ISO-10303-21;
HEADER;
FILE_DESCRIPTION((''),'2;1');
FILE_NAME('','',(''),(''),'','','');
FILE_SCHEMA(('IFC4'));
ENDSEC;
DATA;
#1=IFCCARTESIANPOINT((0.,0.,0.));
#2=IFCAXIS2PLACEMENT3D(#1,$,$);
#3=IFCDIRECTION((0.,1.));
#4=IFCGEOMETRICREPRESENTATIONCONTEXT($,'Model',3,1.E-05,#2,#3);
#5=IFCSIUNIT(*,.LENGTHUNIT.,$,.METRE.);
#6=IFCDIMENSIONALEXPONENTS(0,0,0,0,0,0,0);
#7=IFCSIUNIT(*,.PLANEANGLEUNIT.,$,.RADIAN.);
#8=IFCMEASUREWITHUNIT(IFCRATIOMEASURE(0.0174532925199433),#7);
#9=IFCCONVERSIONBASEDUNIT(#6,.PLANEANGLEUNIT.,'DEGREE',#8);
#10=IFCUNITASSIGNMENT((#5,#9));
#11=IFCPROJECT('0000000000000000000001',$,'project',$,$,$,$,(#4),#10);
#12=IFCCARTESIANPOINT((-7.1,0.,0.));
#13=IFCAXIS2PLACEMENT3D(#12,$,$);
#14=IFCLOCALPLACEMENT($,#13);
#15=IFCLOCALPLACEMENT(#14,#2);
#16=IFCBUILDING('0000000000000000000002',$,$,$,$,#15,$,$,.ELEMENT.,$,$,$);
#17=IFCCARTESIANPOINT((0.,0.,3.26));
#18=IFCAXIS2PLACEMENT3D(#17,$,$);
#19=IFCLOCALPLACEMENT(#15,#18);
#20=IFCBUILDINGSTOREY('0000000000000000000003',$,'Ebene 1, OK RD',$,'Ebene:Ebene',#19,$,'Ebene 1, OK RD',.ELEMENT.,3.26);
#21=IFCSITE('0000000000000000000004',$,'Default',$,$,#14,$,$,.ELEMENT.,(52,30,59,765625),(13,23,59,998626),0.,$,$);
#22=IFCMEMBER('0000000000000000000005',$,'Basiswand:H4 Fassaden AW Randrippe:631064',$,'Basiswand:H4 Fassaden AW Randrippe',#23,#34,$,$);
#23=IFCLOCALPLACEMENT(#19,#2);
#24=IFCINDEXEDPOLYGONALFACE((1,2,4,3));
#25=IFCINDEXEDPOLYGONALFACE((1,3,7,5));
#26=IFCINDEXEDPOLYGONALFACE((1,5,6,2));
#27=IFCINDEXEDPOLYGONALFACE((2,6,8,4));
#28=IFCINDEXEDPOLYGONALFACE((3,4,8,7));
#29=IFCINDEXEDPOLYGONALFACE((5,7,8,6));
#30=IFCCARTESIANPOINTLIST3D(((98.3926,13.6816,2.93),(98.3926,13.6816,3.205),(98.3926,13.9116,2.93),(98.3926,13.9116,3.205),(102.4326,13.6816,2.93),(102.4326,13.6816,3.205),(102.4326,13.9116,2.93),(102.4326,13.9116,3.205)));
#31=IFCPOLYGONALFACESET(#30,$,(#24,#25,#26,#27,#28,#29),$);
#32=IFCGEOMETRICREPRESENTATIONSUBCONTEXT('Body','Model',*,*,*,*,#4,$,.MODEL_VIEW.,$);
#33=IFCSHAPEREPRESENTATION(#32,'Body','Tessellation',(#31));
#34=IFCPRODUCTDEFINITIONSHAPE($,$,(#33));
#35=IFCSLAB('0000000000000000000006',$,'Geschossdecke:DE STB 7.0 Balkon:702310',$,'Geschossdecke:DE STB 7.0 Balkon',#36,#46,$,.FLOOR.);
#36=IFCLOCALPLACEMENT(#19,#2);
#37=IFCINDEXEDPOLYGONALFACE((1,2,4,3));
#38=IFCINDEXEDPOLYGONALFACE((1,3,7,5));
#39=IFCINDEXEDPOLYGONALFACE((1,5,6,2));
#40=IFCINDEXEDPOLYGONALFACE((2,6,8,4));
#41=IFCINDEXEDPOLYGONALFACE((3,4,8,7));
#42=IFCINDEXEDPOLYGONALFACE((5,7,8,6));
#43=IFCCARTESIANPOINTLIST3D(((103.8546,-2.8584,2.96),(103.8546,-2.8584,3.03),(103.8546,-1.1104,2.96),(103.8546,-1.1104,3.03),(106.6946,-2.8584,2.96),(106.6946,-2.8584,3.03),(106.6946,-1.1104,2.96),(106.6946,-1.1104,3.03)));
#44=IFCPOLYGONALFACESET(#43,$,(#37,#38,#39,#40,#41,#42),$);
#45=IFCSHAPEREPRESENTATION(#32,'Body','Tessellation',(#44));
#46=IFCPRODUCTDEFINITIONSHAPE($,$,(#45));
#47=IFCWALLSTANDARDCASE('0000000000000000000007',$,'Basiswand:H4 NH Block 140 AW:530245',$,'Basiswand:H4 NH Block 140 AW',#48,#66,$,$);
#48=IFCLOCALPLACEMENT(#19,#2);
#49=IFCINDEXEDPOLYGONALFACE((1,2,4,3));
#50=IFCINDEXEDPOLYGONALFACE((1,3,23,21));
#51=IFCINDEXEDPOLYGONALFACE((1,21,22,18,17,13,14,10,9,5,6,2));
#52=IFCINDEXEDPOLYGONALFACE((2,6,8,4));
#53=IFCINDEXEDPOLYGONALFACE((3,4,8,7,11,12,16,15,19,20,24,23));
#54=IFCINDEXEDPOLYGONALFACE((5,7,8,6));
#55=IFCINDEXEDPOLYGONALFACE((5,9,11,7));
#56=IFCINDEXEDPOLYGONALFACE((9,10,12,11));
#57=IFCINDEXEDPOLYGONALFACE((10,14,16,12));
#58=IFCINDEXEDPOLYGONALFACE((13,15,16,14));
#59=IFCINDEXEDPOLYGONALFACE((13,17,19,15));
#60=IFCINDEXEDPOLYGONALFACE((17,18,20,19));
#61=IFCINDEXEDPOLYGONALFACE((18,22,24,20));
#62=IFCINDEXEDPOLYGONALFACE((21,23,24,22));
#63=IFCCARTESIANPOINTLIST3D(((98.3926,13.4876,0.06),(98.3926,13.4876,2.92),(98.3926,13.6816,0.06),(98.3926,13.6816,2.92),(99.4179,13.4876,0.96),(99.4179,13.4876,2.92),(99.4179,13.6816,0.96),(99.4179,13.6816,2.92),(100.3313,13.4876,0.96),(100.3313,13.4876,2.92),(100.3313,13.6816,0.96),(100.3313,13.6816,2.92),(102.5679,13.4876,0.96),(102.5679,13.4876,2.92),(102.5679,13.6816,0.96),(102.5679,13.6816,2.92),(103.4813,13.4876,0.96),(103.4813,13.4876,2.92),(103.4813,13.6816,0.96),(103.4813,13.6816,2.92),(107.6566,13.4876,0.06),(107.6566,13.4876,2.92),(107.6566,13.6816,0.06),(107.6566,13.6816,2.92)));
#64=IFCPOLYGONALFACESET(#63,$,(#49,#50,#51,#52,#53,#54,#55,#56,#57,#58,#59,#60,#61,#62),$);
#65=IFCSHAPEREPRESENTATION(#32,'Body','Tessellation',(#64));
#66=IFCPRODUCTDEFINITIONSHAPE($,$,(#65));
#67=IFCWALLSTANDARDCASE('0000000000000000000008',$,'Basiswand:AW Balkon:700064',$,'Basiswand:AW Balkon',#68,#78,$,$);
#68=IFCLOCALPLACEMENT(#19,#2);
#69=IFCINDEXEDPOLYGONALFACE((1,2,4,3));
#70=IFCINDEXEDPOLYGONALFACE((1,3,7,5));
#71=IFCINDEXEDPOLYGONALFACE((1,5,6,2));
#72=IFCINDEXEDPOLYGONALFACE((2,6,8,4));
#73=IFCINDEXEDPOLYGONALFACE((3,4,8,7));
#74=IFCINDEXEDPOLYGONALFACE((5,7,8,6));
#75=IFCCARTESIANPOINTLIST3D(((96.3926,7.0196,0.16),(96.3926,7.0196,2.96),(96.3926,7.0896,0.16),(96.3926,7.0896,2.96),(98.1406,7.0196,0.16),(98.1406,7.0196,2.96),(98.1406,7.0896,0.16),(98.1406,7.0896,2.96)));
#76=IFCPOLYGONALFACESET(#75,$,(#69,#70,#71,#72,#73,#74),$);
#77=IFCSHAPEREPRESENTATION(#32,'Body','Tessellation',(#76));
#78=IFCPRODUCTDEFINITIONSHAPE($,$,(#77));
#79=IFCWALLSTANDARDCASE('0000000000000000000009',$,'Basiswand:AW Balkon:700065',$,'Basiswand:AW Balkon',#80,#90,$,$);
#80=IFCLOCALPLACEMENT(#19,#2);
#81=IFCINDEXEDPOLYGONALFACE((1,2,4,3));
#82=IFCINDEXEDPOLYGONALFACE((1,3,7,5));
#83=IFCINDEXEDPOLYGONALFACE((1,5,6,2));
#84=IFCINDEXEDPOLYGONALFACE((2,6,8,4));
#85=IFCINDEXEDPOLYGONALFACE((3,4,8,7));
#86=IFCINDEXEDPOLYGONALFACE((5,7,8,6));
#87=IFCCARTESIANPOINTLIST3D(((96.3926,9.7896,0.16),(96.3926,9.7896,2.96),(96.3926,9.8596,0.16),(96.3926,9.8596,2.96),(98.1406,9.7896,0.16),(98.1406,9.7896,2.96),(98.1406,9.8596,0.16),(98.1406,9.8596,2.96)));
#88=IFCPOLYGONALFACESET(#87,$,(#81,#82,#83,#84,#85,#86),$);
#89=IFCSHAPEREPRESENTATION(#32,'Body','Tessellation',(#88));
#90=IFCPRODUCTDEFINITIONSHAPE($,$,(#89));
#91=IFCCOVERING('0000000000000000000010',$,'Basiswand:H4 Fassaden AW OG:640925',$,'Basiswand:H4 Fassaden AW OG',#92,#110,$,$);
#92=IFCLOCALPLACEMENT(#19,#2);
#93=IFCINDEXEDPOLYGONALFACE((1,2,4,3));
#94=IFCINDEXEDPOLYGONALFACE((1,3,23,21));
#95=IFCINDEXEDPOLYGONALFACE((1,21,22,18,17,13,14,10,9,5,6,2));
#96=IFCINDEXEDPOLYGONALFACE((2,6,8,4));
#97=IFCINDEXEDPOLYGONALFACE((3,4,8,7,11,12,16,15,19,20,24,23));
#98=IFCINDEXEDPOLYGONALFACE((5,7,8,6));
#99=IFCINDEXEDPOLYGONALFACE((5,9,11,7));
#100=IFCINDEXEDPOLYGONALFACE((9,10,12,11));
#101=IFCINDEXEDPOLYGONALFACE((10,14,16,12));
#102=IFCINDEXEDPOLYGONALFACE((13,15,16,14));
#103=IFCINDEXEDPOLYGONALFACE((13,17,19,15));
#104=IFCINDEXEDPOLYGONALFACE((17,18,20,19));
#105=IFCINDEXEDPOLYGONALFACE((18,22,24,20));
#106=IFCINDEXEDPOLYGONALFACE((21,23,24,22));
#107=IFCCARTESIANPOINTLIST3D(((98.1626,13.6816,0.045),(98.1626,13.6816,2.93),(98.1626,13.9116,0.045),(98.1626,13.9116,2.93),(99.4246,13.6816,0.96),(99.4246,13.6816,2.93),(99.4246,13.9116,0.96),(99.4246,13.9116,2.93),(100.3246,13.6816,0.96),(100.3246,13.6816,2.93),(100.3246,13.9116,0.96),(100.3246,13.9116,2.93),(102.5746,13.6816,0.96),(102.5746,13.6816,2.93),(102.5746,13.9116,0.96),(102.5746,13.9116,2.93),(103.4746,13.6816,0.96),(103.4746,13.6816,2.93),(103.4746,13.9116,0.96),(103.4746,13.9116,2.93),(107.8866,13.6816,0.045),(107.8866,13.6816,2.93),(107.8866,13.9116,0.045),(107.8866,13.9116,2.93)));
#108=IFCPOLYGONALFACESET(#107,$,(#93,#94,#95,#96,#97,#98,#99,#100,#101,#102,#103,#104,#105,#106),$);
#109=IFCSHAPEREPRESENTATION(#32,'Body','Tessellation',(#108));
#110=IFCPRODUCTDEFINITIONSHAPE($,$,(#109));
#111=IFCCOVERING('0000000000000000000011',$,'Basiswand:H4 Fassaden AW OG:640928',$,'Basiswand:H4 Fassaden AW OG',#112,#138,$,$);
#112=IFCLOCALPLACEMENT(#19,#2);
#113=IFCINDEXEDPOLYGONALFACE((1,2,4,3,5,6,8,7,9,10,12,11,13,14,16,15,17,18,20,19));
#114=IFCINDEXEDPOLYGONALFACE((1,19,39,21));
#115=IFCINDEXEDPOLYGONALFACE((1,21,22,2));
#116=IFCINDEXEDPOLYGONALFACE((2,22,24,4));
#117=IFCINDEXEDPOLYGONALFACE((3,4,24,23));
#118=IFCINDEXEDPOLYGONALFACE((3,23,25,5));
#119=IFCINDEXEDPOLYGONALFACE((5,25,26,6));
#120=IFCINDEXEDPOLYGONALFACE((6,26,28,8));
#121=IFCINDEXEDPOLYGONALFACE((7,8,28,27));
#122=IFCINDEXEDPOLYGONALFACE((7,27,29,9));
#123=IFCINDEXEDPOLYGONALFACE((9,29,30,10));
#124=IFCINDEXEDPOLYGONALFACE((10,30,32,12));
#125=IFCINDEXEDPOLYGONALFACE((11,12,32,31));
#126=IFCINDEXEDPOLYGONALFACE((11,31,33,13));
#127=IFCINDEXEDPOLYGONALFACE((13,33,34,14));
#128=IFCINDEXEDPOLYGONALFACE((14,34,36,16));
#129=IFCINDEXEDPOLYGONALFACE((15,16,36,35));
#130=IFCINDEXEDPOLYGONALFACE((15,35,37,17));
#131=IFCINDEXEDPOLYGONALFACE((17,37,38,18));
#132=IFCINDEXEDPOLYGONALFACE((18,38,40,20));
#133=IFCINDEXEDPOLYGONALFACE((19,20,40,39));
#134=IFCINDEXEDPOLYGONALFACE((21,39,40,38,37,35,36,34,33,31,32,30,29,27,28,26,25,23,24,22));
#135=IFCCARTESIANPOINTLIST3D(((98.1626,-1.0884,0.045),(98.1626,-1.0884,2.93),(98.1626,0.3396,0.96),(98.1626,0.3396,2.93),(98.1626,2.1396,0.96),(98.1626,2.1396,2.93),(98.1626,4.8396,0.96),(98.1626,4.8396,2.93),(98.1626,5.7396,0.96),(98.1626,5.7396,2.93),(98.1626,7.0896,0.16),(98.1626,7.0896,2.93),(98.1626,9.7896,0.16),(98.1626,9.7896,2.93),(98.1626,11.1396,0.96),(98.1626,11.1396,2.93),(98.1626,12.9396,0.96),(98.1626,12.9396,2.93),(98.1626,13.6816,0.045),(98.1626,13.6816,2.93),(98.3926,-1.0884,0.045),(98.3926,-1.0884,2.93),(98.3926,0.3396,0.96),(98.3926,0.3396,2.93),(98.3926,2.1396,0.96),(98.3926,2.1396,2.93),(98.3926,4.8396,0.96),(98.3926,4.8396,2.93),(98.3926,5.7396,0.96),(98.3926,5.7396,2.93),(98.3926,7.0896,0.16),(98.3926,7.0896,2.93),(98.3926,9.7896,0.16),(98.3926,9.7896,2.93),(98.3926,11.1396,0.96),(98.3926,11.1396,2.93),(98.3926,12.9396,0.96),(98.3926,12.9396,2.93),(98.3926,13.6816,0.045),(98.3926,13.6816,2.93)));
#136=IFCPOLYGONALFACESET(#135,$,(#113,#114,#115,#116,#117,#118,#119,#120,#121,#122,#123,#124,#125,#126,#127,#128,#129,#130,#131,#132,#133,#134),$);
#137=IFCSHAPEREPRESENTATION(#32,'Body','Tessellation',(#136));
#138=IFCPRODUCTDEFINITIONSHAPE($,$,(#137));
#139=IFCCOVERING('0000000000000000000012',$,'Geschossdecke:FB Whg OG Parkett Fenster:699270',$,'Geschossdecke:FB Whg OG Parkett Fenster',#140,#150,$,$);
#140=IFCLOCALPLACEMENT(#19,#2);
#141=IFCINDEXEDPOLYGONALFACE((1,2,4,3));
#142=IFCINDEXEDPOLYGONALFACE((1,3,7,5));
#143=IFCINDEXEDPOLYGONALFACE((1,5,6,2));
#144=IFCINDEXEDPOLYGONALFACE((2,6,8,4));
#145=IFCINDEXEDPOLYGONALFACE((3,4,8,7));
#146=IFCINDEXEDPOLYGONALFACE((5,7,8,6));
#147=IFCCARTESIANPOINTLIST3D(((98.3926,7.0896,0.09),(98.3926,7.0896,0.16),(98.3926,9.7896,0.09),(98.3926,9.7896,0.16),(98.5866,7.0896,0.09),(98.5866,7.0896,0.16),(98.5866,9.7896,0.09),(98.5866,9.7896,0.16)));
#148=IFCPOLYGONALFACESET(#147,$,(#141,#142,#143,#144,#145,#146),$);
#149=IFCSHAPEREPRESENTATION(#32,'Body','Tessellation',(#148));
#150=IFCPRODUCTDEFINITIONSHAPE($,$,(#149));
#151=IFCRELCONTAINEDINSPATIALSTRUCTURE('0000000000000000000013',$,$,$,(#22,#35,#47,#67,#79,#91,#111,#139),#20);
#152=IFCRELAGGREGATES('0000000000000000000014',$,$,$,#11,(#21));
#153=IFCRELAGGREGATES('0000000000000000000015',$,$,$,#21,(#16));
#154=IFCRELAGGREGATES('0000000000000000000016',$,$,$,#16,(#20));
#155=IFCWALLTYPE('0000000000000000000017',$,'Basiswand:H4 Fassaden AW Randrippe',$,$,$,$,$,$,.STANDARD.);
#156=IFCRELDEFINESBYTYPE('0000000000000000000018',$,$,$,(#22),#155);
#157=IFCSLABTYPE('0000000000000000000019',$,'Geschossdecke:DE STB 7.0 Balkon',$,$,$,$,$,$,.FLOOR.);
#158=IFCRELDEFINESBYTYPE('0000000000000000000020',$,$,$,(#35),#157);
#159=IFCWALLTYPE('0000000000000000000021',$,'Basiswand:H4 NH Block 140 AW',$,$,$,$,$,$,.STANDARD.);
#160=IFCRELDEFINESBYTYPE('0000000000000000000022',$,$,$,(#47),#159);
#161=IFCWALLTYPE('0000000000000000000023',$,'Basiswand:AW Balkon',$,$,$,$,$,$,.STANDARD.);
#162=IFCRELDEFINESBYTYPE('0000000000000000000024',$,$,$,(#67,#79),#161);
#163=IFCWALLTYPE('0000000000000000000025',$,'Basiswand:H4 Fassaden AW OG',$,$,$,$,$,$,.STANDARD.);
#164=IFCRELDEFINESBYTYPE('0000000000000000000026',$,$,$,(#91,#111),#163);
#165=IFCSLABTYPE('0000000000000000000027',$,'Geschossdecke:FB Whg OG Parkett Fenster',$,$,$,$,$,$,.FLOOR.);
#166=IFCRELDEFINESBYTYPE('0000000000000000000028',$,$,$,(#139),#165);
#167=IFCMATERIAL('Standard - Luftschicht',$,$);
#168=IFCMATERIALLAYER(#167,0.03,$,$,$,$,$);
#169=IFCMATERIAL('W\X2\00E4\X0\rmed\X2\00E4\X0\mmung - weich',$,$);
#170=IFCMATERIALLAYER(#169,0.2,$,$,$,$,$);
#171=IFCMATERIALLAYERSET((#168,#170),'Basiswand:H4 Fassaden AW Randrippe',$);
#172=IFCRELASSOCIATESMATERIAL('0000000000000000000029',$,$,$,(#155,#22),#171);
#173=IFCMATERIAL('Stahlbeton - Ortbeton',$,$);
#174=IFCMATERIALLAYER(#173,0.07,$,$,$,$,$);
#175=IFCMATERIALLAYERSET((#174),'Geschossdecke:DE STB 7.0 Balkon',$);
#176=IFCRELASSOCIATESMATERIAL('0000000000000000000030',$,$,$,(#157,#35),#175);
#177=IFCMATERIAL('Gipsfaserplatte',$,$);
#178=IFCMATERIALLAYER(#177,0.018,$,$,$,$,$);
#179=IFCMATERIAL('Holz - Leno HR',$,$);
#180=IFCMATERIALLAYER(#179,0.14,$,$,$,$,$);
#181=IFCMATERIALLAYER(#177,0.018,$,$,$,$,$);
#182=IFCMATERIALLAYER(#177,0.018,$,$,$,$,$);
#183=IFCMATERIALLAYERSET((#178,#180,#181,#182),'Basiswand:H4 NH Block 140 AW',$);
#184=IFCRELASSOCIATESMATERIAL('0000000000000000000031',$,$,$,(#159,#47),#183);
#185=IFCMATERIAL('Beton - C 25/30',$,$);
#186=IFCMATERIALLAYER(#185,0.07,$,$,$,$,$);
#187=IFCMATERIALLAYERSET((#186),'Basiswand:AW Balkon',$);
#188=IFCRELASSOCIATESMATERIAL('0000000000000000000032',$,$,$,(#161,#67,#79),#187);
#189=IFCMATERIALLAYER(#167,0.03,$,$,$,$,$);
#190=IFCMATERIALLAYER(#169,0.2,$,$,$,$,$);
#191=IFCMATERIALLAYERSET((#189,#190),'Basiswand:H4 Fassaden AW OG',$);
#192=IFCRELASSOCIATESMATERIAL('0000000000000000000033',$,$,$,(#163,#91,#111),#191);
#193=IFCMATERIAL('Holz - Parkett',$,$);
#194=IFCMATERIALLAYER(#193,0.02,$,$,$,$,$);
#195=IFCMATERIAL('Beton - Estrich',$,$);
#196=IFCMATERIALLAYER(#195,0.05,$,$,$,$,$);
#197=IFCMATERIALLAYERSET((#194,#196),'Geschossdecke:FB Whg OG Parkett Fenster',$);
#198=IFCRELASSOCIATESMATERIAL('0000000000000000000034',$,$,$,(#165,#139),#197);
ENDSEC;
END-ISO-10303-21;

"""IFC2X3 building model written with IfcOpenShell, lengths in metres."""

from ifc_helpers import new_model, entity, si_unit, converted_unit, direction, frame, frame_2d, origin, origin_2d_with_axis, place, context, subcontext, project, spatial, rectangle, extrude, material, layer, layer_set, layer_usage, type_object, element, save


model = new_model("IFC2X3")

# Units and contexts
model_context = context("Model", 3, precision=1e-05, world=origin(), true_north=direction((0.0, 1.0)))
body_context = subcontext(model_context, "Body", "Model", "MODEL_VIEW")
ifc_project = project(units=[si_unit("LENGTHUNIT", "METRE"), converted_unit("PLANEANGLEUNIT", "DEGREE", entity("IfcRatioMeasure", 0.0174532925199433), si_unit("PLANEANGLEUNIT", "RADIAN"), dimensions=[0, 0, 0, 0, 0, 0, 0])], contexts=[model_context])

# Site, building, storey
site_placement = place(None, frame((-7.1, 0.0, 0.0)))
site = spatial("IfcSite", under=ifc_project, at=site_placement, Name="Default", CompositionType="ELEMENT", RefLatitude=(52, 30, 59, 765625), RefLongitude=(13, 23, 59, 998626), RefElevation=0.0)
building_placement = place(site_placement, origin())
building = spatial("IfcBuilding", under=site, at=building_placement, CompositionType="ELEMENT")
storey_placement = place(building_placement, frame((0.0, 0.0, 3.26)))
storey = spatial("IfcBuildingStorey", under=building, at=storey_placement, Name="Ebene 1, OK RD", ObjectType="Ebene:Ebene", LongName="Ebene 1, OK RD", CompositionType="ELEMENT", Elevation=3.26)

# Shared definitions
ifc_material_1 = material(Name="Gipsfaserplatte")

# Member
ifc_material_2 = material(Name="Standard - Luftschicht")
ifc_layer_1 = layer(ifc_material_2, 0.03)
ifc_material_3 = material(Name="Wärmedämmung - weich")
ifc_layer_2 = layer(ifc_material_3, 0.2)
ifc_layer_set_1 = layer_set([ifc_layer_1, ifc_layer_2], Name="Basiswand:H4 Fassaden AW Randrippe")
ifc_layer_usage_1 = layer_usage(ifc_layer_set_1, "AXIS2", "NEGATIVE", 0.115)
wall_type_1 = type_object("IfcWallType", Name="Basiswand:H4 Fassaden AW Randrippe", PredefinedType="STANDARD", material=ifc_layer_set_1)
member_1_placement = place(storey_placement, frame((98.3926, 13.7966, 2.93)))
element("IfcMember", 1, at=member_1_placement, inside=storey, type_object=wall_type_1, material=ifc_layer_usage_1, Name="Basiswand:H4 Fassaden AW Randrippe:631064", ObjectType="Basiswand:H4 Fassaden AW Randrippe", context=body_context, shape_type="SweptSolid", body=[
    extrude(rectangle(XDim=4.04, YDim=0.23, at=frame_2d((2.02, 0.0), x_axis=(-1.0, 0.0))), origin(), (0.0, 0.0, 1.0), 0.275),
])

# Slab
ifc_material_4 = material(Name="Stahlbeton - Ortbeton")
ifc_layer_3 = layer(ifc_material_4, 0.07)
ifc_layer_set_2 = layer_set([ifc_layer_3], Name="Geschossdecke:DE STB 7.0 Balkon")
ifc_layer_usage_2 = layer_usage(ifc_layer_set_2, "AXIS3", "POSITIVE", 0.0)
slab_type_1 = type_object("IfcSlabType", Name="Geschossdecke:DE STB 7.0 Balkon", PredefinedType="FLOOR", material=ifc_layer_set_2)
slab_placement = place(storey_placement, origin())
element("IfcSlab", 2, at=slab_placement, inside=storey, type_object=slab_type_1, material=ifc_layer_usage_2, Name="Geschossdecke:DE STB 7.0 Balkon:702310", ObjectType="Geschossdecke:DE STB 7.0 Balkon", PredefinedType="FLOOR", context=body_context, shape_type="SweptSolid", body=[
    extrude(rectangle(XDim=1.748, YDim=2.84, at=frame_2d((0.0, 0.0), x_axis=(1.0, 0.0))), frame((105.2746, -1.9844, 3.03), z_axis=(0.0, 0.0, -1.0), x_axis=(0.0, 1.0, 0.0)), (0.0, 0.0, 1.0), 0.07),
])

# Wall, openings
ifc_layer_4 = layer(ifc_material_1, 0.018)
ifc_material_5 = material(Name="Holz - Leno HR")
ifc_layer_5 = layer(ifc_material_5, 0.14)
ifc_layer_6 = layer(ifc_material_1, 0.018)
ifc_layer_7 = layer(ifc_material_1, 0.018)
ifc_layer_set_3 = layer_set([ifc_layer_4, ifc_layer_5, ifc_layer_6, ifc_layer_7], Name="Basiswand:H4 NH Block 140 AW")
ifc_layer_usage_3 = layer_usage(ifc_layer_set_3, "AXIS2", "NEGATIVE", 0.097)
wall_type_2 = type_object("IfcWallType", Name="Basiswand:H4 NH Block 140 AW", PredefinedType="STANDARD", material=ifc_layer_set_3)
wall_1_placement = place(storey_placement, frame((98.3926, 13.5846, 0.06)))
wall_1 = element("IfcWallStandardCase", 3, at=wall_1_placement, inside=storey, type_object=wall_type_2, material=ifc_layer_usage_3, Name="Basiswand:H4 NH Block 140 AW:530245", ObjectType="Basiswand:H4 NH Block 140 AW", context=body_context, shape_type="SweptSolid", body=[
    extrude(rectangle(XDim=9.264, YDim=0.194, at=frame_2d((4.632, 0.0), x_axis=(-1.0, 0.0))), origin(), (0.0, 0.0, 1.0), 2.86),
])
opening_1_placement = place(wall_1_placement, origin())
element("IfcOpeningElement", 4, at=opening_1_placement, cuts=wall_1, ObjectType="Opening", context=body_context, shape_type="SweptSolid", body=[
    extrude(rectangle(XDim=2.0, YDim=0.9134, at=origin_2d_with_axis()), frame((1.482, -0.097, 1.9), z_axis=(0.0, 1.0, 0.0), x_axis=(0.0, 0.0, -1.0)), (0.0, 0.0, 1.0), 0.194),
])
opening_2_placement = place(wall_1_placement, origin())
element("IfcOpeningElement", 5, at=opening_2_placement, cuts=wall_1, ObjectType="Opening", context=body_context, shape_type="SweptSolid", body=[
    extrude(rectangle(XDim=2.0, YDim=0.9134, at=origin_2d_with_axis()), frame((4.632, -0.097, 1.9), z_axis=(0.0, 1.0, 0.0), x_axis=(0.0, 0.0, -1.0)), (0.0, 0.0, 1.0), 0.194),
])

# Walls
ifc_material_6 = material(Name="Beton - C 25/30")
ifc_layer_8 = layer(ifc_material_6, 0.07)
ifc_layer_set_4 = layer_set([ifc_layer_8], Name="Basiswand:AW Balkon")
ifc_layer_usage_4 = layer_usage(ifc_layer_set_4, "AXIS2", "NEGATIVE", 0.035)
wall_type_3 = type_object("IfcWallType", Name="Basiswand:AW Balkon", PredefinedType="STANDARD", material=ifc_layer_set_4)
wall_2_placement = place(storey_placement, frame((98.1406, 7.0546, 0.16), z_axis=(0.0, 0.0, 1.0), x_axis=(-1.0, 0.0, 0.0)))
element("IfcWallStandardCase", 6, at=wall_2_placement, inside=storey, type_object=wall_type_3, material=ifc_layer_usage_4, Name="Basiswand:AW Balkon:700064", ObjectType="Basiswand:AW Balkon", context=body_context, shape_type="SweptSolid", body=[
    extrude(rectangle(XDim=1.748, YDim=0.07, at=frame_2d((0.874, 0.0), x_axis=(-1.0, 0.0))), origin(), (0.0, 0.0, 1.0), 2.8),
])
ifc_layer_usage_5 = layer_usage(ifc_layer_set_4, "AXIS2", "NEGATIVE", 0.035)
wall_3_placement = place(storey_placement, frame((96.3926, 9.8246, 0.16)))
element("IfcWallStandardCase", 7, at=wall_3_placement, inside=storey, type_object=wall_type_3, material=ifc_layer_usage_5, Name="Basiswand:AW Balkon:700065", ObjectType="Basiswand:AW Balkon", context=body_context, shape_type="SweptSolid", body=[
    extrude(rectangle(XDim=1.748, YDim=0.07, at=frame_2d((0.874, 0.0), x_axis=(-1.0, 0.0))), origin(), (0.0, 0.0, 1.0), 2.8),
])

# Coverings, openings
ifc_layer_9 = layer(ifc_material_2, 0.03)
ifc_layer_10 = layer(ifc_material_3, 0.2)
ifc_layer_set_5 = layer_set([ifc_layer_9, ifc_layer_10], Name="Basiswand:H4 Fassaden AW OG")
ifc_layer_usage_6 = layer_usage(ifc_layer_set_5, "AXIS2", "NEGATIVE", 0.115)
wall_type_4 = type_object("IfcWallType", Name="Basiswand:H4 Fassaden AW OG", PredefinedType="STANDARD", material=ifc_layer_set_5)
covering_1_placement = place(storey_placement, frame((98.1626, 13.7966, 0.045)))
covering_1 = element("IfcCovering", 8, at=covering_1_placement, inside=storey, type_object=wall_type_4, material=ifc_layer_usage_6, Name="Basiswand:H4 Fassaden AW OG:640925", ObjectType="Basiswand:H4 Fassaden AW OG", context=body_context, shape_type="SweptSolid", body=[
    extrude(rectangle(XDim=9.724, YDim=0.23, at=frame_2d((4.862, 0.0), x_axis=(-1.0, 0.0))), origin(), (0.0, 0.0, 1.0), 2.885),
])
opening_3_placement = place(covering_1_placement, frame((2.162, 0.115, 0.915)))
element("IfcOpeningElement", 9, at=opening_3_placement, cuts=covering_1, ObjectType="Opening", context=body_context, shape_type="SweptSolid", body=[
    extrude(rectangle(XDim=1.97, YDim=0.9, at=frame_2d((0.985, 0.45), x_axis=(1.0, 0.0))), frame((0.0, 0.0, 0.0), z_axis=(0.0, -1.0, 0.0), x_axis=(0.0, 0.0, 1.0)), (0.0, 0.0, 1.0), 0.23),
])
opening_4_placement = place(covering_1_placement, frame((5.312, 0.115, 0.915)))
element("IfcOpeningElement", 10, at=opening_4_placement, cuts=covering_1, ObjectType="Opening", context=body_context, shape_type="SweptSolid", body=[
    extrude(rectangle(XDim=1.97, YDim=0.9, at=frame_2d((0.985, 0.45), x_axis=(1.0, 0.0))), frame((0.0, 0.0, 0.0), z_axis=(0.0, -1.0, 0.0), x_axis=(0.0, 0.0, 1.0)), (0.0, 0.0, 1.0), 0.23),
])
ifc_layer_usage_7 = layer_usage(ifc_layer_set_5, "AXIS2", "NEGATIVE", 0.115)
covering_2_placement = place(storey_placement, frame((98.2776, -1.0884, 0.045), z_axis=(0.0, 0.0, 1.0), x_axis=(0.0, 1.0, 0.0)))
covering_2 = element("IfcCovering", 11, at=covering_2_placement, inside=storey, type_object=wall_type_4, material=ifc_layer_usage_7, Name="Basiswand:H4 Fassaden AW OG:640928", ObjectType="Basiswand:H4 Fassaden AW OG", context=body_context, shape_type="SweptSolid", body=[
    extrude(rectangle(XDim=14.77, YDim=0.23, at=frame_2d((7.385, 0.0), x_axis=(-1.0, 0.0))), origin(), (0.0, 0.0, 1.0), 2.885),
])
opening_5_placement = place(covering_2_placement, origin())
element("IfcOpeningElement", 12, at=opening_5_placement, cuts=covering_2, ObjectType="Opening", context=body_context, shape_type="SweptSolid", body=[
    extrude(rectangle(XDim=2.8, YDim=2.7, at=frame_2d((0.0, 0.0), x_axis=(0.0, 1.0))), frame((9.528, -0.2674, 1.515), z_axis=(0.0, 1.0, 0.0), x_axis=(-1.0, 0.0, 0.0)), (0.0, 0.0, 1.0), 0.5348),
])
opening_6_placement = place(covering_2_placement, frame((3.228, 0.115, 0.915)))
element("IfcOpeningElement", 13, at=opening_6_placement, cuts=covering_2, ObjectType="Opening", context=body_context, shape_type="SweptSolid", body=[
    extrude(rectangle(XDim=1.97, YDim=1.8, at=frame_2d((0.985, 0.9), x_axis=(1.0, 0.0))), frame((0.0, 0.0, 0.0), z_axis=(0.0, -1.0, 0.0), x_axis=(0.0, 0.0, 1.0)), (0.0, 0.0, 1.0), 0.23),
])
opening_7_placement = place(covering_2_placement, frame((14.028, 0.115, 0.915)))
element("IfcOpeningElement", 14, at=opening_7_placement, cuts=covering_2, ObjectType="Opening", context=body_context, shape_type="SweptSolid", body=[
    extrude(rectangle(XDim=1.97, YDim=1.8, at=frame_2d((0.985, 0.9), x_axis=(1.0, 0.0))), frame((0.0, 0.0, 0.0), z_axis=(0.0, -1.0, 0.0), x_axis=(0.0, 0.0, 1.0)), (0.0, 0.0, 1.0), 0.23),
])
opening_8_placement = place(covering_2_placement, frame((6.828, 0.115, 0.915)))
element("IfcOpeningElement", 15, at=opening_8_placement, cuts=covering_2, ObjectType="Opening", context=body_context, shape_type="SweptSolid", body=[
    extrude(rectangle(XDim=1.97, YDim=0.9, at=frame_2d((0.985, 0.45), x_axis=(1.0, 0.0))), frame((0.0, 0.0, 0.0), z_axis=(0.0, -1.0, 0.0), x_axis=(0.0, 0.0, 1.0)), (0.0, 0.0, 1.0), 0.23),
])

# Covering
ifc_material_7 = material(Name="Holz - Parkett")
ifc_layer_11 = layer(ifc_material_7, 0.02)
ifc_material_8 = material(Name="Beton - Estrich")
ifc_layer_12 = layer(ifc_material_8, 0.05)
ifc_layer_set_6 = layer_set([ifc_layer_11, ifc_layer_12], Name="Geschossdecke:FB Whg OG Parkett Fenster")
ifc_layer_usage_8 = layer_usage(ifc_layer_set_6, "AXIS3", "POSITIVE", 0.0)
slab_type_2 = type_object("IfcSlabType", Name="Geschossdecke:FB Whg OG Parkett Fenster", PredefinedType="FLOOR", material=ifc_layer_set_6)
covering_3_placement = place(storey_placement, origin())
element("IfcCovering", 16, at=covering_3_placement, inside=storey, type_object=slab_type_2, material=ifc_layer_usage_8, Name="Geschossdecke:FB Whg OG Parkett Fenster:699270", ObjectType="Geschossdecke:FB Whg OG Parkett Fenster", context=body_context, shape_type="SweptSolid", body=[
    extrude(rectangle(XDim=2.7, YDim=0.194, at=origin_2d_with_axis()), frame((98.4896, 8.4396, 0.16), z_axis=(0.0, 0.0, -1.0), x_axis=(0.0, 1.0, 0.0)), (0.0, 0.0, 1.0), 0.07),
])

save(model, "model.ifc")
